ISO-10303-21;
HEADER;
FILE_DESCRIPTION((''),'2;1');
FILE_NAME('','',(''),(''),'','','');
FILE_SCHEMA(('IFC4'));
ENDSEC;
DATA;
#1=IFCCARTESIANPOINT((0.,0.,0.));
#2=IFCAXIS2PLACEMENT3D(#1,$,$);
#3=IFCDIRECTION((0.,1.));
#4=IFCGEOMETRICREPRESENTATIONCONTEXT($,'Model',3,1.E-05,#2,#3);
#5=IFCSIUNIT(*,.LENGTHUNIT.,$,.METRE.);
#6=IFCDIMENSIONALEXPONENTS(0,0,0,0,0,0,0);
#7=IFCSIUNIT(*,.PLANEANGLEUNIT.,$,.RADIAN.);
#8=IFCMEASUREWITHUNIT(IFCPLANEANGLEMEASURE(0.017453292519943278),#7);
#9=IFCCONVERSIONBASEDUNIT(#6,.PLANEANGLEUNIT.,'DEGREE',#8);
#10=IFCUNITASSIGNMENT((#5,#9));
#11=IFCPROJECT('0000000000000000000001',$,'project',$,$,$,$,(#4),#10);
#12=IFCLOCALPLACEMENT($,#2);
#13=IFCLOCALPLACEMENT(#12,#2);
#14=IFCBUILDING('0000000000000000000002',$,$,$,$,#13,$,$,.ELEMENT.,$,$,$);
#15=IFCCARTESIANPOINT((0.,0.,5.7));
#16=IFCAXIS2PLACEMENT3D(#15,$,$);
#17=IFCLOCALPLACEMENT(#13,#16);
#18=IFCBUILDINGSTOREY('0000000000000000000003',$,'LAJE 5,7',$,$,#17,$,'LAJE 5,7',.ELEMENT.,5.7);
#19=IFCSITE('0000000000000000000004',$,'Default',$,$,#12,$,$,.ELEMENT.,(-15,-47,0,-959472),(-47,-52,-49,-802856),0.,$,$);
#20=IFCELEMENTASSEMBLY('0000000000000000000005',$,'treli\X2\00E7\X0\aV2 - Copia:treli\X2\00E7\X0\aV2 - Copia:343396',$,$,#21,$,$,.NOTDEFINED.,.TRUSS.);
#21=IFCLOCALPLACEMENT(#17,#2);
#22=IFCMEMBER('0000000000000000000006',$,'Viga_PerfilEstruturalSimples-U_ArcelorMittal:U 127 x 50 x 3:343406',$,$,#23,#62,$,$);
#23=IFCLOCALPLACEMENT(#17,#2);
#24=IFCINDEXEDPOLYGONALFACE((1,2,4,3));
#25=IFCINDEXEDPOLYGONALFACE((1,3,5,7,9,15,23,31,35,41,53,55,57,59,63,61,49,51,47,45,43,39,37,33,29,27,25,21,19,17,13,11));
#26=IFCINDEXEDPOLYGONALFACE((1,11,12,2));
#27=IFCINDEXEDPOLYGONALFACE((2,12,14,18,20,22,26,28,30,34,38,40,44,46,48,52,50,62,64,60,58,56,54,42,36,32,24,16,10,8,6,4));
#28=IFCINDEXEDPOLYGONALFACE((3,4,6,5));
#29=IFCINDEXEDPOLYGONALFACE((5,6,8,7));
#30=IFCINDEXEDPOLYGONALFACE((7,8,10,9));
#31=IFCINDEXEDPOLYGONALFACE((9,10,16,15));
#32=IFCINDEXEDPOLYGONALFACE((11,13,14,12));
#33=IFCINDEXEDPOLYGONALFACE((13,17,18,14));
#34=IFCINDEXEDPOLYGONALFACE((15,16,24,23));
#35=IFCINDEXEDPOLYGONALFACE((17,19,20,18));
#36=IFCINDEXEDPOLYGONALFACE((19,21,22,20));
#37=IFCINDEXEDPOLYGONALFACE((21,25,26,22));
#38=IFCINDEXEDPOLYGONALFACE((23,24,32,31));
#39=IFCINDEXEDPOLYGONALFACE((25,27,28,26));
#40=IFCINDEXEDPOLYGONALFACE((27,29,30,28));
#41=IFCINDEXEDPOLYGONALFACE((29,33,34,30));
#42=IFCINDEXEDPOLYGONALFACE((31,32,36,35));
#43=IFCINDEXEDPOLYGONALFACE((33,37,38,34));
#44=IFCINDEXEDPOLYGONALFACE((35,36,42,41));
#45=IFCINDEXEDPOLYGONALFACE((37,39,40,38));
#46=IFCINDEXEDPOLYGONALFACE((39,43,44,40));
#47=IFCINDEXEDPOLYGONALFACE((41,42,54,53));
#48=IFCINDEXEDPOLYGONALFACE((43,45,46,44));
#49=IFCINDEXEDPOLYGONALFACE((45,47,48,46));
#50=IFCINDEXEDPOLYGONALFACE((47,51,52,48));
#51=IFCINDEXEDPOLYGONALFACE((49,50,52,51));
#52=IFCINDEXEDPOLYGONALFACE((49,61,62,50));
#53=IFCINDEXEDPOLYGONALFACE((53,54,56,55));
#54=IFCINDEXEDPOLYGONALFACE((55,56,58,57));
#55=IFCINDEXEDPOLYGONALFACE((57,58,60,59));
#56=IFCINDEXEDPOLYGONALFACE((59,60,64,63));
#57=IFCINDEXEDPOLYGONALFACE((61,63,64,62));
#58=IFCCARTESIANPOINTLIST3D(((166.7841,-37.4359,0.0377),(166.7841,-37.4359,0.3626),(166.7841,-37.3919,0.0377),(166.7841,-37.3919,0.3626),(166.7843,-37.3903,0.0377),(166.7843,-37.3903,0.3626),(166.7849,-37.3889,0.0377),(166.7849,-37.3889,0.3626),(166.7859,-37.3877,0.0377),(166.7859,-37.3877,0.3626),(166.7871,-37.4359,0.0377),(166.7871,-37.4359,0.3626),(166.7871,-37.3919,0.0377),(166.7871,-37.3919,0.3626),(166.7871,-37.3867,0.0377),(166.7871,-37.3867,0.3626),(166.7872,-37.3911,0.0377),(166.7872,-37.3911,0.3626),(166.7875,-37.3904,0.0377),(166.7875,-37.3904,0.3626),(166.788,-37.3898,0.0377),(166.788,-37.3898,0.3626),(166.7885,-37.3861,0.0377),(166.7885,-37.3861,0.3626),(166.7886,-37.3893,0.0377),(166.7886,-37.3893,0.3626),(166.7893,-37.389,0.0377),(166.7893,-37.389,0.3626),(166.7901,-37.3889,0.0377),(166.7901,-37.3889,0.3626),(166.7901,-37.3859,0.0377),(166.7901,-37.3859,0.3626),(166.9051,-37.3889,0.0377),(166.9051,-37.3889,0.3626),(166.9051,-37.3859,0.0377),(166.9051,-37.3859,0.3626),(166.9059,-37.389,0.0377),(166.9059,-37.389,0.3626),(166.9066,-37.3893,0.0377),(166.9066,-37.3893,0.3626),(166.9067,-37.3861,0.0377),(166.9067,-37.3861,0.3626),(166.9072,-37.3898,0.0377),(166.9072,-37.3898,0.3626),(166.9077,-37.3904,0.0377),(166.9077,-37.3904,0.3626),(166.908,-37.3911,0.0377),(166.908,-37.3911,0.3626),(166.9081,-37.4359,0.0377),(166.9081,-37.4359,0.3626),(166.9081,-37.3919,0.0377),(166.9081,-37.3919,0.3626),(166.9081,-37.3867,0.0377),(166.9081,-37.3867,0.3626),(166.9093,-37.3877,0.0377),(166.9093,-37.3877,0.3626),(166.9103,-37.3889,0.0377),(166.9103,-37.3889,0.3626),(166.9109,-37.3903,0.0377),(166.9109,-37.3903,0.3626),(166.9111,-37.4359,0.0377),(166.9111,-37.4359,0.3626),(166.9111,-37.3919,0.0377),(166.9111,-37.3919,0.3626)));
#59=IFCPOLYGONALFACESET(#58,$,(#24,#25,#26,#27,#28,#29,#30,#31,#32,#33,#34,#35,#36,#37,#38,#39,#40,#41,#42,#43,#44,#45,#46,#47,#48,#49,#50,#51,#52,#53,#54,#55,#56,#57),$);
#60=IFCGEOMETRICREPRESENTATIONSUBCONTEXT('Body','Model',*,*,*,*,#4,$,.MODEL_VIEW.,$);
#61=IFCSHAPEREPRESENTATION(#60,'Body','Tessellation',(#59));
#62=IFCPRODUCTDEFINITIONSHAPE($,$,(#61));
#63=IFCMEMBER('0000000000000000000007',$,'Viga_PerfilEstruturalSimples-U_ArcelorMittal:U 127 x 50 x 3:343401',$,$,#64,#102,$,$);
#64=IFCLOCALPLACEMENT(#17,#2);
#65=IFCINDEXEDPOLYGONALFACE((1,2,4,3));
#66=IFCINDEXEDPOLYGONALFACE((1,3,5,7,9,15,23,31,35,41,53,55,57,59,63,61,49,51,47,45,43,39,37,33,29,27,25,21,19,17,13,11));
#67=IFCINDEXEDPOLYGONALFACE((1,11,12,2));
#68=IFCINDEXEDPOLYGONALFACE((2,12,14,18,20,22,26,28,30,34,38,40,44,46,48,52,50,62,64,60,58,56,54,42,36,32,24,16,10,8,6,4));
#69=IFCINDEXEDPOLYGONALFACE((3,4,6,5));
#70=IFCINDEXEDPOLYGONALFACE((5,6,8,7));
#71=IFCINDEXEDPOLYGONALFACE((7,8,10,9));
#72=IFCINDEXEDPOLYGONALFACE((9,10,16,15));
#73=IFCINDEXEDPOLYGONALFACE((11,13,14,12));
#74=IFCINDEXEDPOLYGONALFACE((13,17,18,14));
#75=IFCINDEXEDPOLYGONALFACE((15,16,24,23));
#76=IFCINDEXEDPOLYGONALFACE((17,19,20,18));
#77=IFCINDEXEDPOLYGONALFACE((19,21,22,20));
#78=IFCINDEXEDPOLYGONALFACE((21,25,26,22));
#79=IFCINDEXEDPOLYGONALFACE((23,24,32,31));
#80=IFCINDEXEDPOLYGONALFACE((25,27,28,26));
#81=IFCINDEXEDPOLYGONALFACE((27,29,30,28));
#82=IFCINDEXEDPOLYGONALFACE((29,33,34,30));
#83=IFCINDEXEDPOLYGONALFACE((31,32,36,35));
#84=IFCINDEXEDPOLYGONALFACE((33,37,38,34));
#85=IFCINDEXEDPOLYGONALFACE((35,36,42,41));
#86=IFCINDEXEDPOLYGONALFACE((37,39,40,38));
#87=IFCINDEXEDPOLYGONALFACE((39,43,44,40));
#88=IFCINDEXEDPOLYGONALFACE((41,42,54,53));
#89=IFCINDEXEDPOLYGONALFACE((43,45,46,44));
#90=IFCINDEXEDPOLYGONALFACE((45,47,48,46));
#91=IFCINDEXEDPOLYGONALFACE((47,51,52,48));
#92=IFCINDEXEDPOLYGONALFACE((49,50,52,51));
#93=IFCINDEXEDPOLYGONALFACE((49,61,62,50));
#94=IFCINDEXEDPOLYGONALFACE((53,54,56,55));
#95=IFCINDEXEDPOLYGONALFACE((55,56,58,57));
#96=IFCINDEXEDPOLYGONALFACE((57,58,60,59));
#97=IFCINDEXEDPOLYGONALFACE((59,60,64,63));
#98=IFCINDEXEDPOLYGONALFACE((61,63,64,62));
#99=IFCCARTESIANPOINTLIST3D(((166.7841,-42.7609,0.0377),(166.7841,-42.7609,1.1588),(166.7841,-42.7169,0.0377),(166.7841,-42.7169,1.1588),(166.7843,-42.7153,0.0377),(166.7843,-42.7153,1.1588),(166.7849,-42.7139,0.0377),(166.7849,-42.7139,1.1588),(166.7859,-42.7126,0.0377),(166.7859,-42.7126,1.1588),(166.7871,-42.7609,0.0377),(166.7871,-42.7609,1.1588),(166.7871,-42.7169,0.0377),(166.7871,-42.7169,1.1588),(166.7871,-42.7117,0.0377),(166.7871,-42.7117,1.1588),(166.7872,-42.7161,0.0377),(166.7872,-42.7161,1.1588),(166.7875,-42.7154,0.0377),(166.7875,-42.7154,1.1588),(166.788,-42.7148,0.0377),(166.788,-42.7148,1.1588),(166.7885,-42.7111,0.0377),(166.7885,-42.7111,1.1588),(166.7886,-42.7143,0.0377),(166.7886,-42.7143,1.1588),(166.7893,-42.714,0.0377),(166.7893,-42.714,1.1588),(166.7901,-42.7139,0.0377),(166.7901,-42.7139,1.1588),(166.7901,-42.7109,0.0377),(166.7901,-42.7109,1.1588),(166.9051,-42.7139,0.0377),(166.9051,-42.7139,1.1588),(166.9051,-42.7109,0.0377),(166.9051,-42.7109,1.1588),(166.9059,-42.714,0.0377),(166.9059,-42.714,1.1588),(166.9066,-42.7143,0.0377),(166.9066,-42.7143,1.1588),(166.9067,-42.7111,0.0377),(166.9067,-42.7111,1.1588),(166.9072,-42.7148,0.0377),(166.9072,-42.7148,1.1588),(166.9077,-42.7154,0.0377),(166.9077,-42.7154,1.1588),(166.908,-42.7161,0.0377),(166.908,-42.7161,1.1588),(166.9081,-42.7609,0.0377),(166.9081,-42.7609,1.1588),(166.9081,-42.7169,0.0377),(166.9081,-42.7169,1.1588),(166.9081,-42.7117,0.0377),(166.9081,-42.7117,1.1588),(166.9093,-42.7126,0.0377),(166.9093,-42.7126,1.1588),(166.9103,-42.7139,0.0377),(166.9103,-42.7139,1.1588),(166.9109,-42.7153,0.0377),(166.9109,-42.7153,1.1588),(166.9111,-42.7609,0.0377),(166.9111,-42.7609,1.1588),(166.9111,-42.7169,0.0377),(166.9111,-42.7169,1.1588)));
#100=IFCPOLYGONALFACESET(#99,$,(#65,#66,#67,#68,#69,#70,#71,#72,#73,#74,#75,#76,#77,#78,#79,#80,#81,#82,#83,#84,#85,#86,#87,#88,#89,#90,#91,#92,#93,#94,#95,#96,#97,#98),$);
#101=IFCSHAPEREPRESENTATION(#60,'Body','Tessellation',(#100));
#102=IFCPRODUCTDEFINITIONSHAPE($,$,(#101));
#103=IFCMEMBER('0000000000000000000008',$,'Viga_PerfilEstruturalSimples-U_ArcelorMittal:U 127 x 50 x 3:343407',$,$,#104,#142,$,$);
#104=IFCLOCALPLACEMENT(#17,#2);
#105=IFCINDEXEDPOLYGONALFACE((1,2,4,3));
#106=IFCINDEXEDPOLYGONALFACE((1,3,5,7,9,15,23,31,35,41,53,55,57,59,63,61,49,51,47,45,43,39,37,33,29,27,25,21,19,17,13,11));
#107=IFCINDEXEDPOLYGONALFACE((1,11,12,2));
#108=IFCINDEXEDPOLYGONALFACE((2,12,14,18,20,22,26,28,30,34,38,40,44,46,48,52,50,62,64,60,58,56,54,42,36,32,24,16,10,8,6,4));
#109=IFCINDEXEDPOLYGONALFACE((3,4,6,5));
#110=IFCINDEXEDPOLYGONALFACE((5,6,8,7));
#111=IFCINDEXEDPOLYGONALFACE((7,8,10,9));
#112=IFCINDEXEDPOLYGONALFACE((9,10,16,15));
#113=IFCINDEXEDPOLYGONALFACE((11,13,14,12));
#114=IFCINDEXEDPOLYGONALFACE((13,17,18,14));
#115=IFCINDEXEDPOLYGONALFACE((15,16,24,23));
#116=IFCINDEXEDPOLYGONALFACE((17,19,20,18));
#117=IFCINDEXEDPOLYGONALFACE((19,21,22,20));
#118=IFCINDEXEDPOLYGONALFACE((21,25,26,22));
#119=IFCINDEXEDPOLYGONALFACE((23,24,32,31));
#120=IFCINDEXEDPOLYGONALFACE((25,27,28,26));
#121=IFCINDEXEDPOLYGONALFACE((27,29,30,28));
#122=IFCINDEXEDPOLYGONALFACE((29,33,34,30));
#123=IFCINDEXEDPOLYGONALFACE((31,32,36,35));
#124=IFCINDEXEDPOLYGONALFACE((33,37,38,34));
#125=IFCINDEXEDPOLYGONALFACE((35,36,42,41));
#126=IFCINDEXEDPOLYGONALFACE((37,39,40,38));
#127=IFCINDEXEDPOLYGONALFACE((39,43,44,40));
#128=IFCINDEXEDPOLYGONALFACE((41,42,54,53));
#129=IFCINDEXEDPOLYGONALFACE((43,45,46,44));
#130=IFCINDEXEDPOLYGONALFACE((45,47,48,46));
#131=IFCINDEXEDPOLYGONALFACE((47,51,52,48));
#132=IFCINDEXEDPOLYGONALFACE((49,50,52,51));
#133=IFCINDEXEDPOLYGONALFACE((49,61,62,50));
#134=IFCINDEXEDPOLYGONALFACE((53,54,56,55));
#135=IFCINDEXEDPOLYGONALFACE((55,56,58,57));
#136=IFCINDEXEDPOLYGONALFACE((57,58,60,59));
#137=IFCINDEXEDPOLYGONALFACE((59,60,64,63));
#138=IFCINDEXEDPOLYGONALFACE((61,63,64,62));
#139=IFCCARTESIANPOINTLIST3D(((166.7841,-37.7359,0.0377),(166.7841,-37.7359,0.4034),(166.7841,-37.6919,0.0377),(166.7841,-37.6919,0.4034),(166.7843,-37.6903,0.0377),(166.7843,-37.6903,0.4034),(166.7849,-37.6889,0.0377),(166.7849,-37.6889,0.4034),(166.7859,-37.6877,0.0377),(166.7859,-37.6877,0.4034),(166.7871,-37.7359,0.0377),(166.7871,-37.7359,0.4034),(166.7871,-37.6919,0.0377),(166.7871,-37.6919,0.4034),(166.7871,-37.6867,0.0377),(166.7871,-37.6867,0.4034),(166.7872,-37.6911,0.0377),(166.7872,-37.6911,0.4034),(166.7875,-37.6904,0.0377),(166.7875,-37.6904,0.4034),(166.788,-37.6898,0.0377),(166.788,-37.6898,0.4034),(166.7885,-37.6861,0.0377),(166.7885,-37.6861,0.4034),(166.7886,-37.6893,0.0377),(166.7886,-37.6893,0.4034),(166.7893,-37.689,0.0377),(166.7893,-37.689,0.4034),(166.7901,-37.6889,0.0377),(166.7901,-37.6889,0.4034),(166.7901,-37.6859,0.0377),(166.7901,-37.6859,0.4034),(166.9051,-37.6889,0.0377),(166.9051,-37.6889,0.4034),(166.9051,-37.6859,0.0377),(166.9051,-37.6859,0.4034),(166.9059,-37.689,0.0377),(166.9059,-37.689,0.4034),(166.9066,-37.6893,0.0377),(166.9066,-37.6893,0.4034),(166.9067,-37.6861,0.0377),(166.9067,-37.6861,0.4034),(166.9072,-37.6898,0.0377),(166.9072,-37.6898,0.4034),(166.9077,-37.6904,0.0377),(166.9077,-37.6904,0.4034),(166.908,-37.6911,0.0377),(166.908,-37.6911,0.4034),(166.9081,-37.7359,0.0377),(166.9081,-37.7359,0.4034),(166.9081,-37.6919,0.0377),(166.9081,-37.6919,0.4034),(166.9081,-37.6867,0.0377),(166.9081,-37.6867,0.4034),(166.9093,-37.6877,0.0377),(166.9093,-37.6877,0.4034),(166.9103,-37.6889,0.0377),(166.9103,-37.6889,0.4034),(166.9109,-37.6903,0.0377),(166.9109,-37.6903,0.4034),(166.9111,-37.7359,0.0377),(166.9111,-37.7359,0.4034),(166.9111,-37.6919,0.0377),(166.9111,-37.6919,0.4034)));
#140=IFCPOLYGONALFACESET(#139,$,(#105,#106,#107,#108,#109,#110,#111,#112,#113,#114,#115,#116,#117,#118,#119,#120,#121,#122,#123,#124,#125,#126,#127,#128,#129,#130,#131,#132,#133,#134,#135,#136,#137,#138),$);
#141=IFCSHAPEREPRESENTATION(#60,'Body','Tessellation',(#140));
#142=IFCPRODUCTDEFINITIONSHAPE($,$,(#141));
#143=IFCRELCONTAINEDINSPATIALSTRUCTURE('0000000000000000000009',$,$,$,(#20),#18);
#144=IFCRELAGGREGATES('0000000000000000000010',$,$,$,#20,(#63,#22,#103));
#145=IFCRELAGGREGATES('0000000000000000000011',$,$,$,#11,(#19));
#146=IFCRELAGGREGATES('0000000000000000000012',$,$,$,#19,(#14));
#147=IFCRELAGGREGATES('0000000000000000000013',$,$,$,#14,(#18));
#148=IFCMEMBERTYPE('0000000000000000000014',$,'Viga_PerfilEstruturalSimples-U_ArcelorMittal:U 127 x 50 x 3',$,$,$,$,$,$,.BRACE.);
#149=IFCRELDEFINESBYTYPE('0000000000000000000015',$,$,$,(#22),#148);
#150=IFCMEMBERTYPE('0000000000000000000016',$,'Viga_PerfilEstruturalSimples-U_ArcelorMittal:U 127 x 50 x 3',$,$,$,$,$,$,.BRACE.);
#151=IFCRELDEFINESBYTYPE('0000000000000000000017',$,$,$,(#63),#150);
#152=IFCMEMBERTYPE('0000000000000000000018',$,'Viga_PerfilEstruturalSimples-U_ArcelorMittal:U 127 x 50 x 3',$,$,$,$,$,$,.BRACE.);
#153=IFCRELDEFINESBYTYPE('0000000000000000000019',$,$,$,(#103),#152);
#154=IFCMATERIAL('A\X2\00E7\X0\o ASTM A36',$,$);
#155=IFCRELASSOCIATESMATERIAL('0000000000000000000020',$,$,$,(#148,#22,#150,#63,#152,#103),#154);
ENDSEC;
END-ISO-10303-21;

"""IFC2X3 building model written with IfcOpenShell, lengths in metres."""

from ifc_helpers import new_model, entity, si_unit, converted_unit, direction, frame, frame_2d, origin, place, context, subcontext, project, spatial, polyline, circle_curve, parameter, trimmed, segment, composite_curve, outline, extrude, source, transform, mapped, material, type_object, type_shapes, element, aggregate, save


model = new_model("IFC2X3")

# Units and contexts
model_context = context("Model", 3, precision=1e-05, world=origin(), true_north=direction((0.0, 1.0)))
body_context = subcontext(model_context, "Body", "Model", "MODEL_VIEW")
ifc_project = project(units=[si_unit("LENGTHUNIT", "METRE"), converted_unit("PLANEANGLEUNIT", "DEGREE", entity("IfcPlaneAngleMeasure", 0.017453292519943278), si_unit("PLANEANGLEUNIT", "RADIAN"), dimensions=[0, 0, 0, 0, 0, 0, 0])], contexts=[model_context])

# Site, building, storey
site_placement = place(None, origin())
site = spatial("IfcSite", under=ifc_project, at=site_placement, Name="Default", CompositionType="ELEMENT", RefLatitude=(-15, -47, 0, -959472), RefLongitude=(-47, -52, -49, -802856), RefElevation=0.0)
building_placement = place(site_placement, origin())
building = spatial("IfcBuilding", under=site, at=building_placement, CompositionType="ELEMENT")
storey_placement = place(building_placement, frame((0.0, 0.0, 5.7)))
storey = spatial("IfcBuildingStorey", under=building, at=storey_placement, Name="LAJE 5,7", LongName="LAJE 5,7", CompositionType="ELEMENT", Elevation=5.7)

# Element assembly, member
assembly_1_placement = place(storey_placement, origin())
assembly_1 = element("IfcElementAssembly", 1, at=assembly_1_placement, inside=storey, Name="treliçaV2 - Copia:treliçaV2 - Copia:343396", AssemblyPlace="NOTDEFINED", PredefinedType="TRUSS")
ifc_material = material(Name="Aço ASTM A36")
member_type_1 = type_object("IfcMemberType", Name="Viga_PerfilEstruturalSimples-U_ArcelorMittal:U 127 x 50 x 3", PredefinedType="BRACE", material=ifc_material)
shared_shape_1 = source(origin(), body_context, "Body", "SweptSolid", [
    extrude(outline(composite_curve([segment(polyline([(-0.0575, -0.0192), (0.0575, -0.0192)]), True, "CONTINUOUS"), segment(trimmed(circle_curve(frame_2d((0.0575, -0.0132), x_axis=(0.0, 1.0)), 0.006), [parameter(180.0)], [parameter(270.0)], True, "PARAMETER"), True, "CONTINUOUS"), segment(polyline([(0.0635, -0.0132), (0.0635, 0.0308)]), True, "CONTINUOUS"), segment(polyline([(0.0635, 0.0308), (0.0605, 0.0308)]), True, "CONTINUOUS"), segment(polyline([(0.0605, 0.0308), (0.0605, -0.0132)]), True, "CONTINUOUS"), segment(trimmed(circle_curve(frame_2d((0.0575, -0.0132), x_axis=(0.0, 1.0)), 0.003), [parameter(180.0)], [parameter(270.0)], True, "PARAMETER"), False, "CONTINUOUS"), segment(polyline([(0.0575, -0.0162), (-0.0575, -0.0162)]), True, "CONTINUOUS"), segment(trimmed(circle_curve(frame_2d((-0.0575, -0.0132), x_axis=(0.0, 1.0)), 0.003), [parameter(90.0)], [parameter(180.0)], True, "PARAMETER"), False, "CONTINUOUS"), segment(polyline([(-0.0605, -0.0132), (-0.0605, 0.0308)]), True, "CONTINUOUS"), segment(polyline([(-0.0605, 0.0308), (-0.0635, 0.0308)]), True, "CONTINUOUS"), segment(polyline([(-0.0635, 0.0308), (-0.0635, -0.0132)]), True, "CONTINUOUS"), segment(trimmed(circle_curve(frame_2d((-0.0575, -0.0132), x_axis=(0.0, 1.0)), 0.006), [parameter(90.0)], [parameter(180.0)], True, "PARAMETER"), True, "CONTINUOUS")], self_intersect=False)), frame((-0.1623, -0.0058, 0.0), z_axis=(1.0, 0.0, 0.0), x_axis=(0.0, 0.0, -1.0)), (0.0, 0.0, 1.0), 0.3249),
])
type_shapes(member_type_1, [shared_shape_1])
member_1_placement = place(assembly_1_placement, frame((166.8476, -37.4109, 0.2), z_axis=(1.0, 0.0, 0.0), x_axis=(0.0, 0.0, 1.0)))
member_1 = element("IfcMember", 2, at=member_1_placement, type_object=member_type_1, material=ifc_material, Name="Viga_PerfilEstruturalSimples-U_ArcelorMittal:U 127 x 50 x 3:343406", context=body_context, shape_type="MappedRepresentation", body=[
    mapped(shared_shape_1, transform((0.0, 0.0, 0.0), scale=1.0)),
])

# Members
member_type_2 = type_object("IfcMemberType", Name="Viga_PerfilEstruturalSimples-U_ArcelorMittal:U 127 x 50 x 3", PredefinedType="BRACE", material=ifc_material)
shared_shape_2 = source(origin(), body_context, "Body", "SweptSolid", [
    extrude(outline(composite_curve([segment(polyline([(-0.0575, -0.0192), (0.0575, -0.0192)]), True, "CONTINUOUS"), segment(trimmed(circle_curve(frame_2d((0.0575, -0.0132), x_axis=(0.0, 1.0)), 0.006), [parameter(180.0)], [parameter(270.0)], True, "PARAMETER"), True, "CONTINUOUS"), segment(polyline([(0.0635, -0.0132), (0.0635, 0.0308)]), True, "CONTINUOUS"), segment(polyline([(0.0635, 0.0308), (0.0605, 0.0308)]), True, "CONTINUOUS"), segment(polyline([(0.0605, 0.0308), (0.0605, -0.0132)]), True, "CONTINUOUS"), segment(trimmed(circle_curve(frame_2d((0.0575, -0.0132), x_axis=(0.0, 1.0)), 0.003), [parameter(180.0)], [parameter(270.0)], True, "PARAMETER"), False, "CONTINUOUS"), segment(polyline([(0.0575, -0.0162), (-0.0575, -0.0162)]), True, "CONTINUOUS"), segment(trimmed(circle_curve(frame_2d((-0.0575, -0.0132), x_axis=(0.0, 1.0)), 0.003), [parameter(90.0)], [parameter(180.0)], True, "PARAMETER"), False, "CONTINUOUS"), segment(polyline([(-0.0605, -0.0132), (-0.0605, 0.0308)]), True, "CONTINUOUS"), segment(polyline([(-0.0605, 0.0308), (-0.0635, 0.0308)]), True, "CONTINUOUS"), segment(polyline([(-0.0635, 0.0308), (-0.0635, -0.0132)]), True, "CONTINUOUS"), segment(trimmed(circle_curve(frame_2d((-0.0575, -0.0132), x_axis=(0.0, 1.0)), 0.006), [parameter(90.0)], [parameter(180.0)], True, "PARAMETER"), True, "CONTINUOUS")], self_intersect=False)), frame((-0.5626, -0.0058, 0.0), z_axis=(1.0, 0.0, 0.0), x_axis=(0.0, 0.0, -1.0)), (0.0, 0.0, 1.0), 1.1211),
])
type_shapes(member_type_2, [shared_shape_2])
member_2_placement = place(assembly_1_placement, frame((166.8476, -42.7359, 0.6003), z_axis=(1.0, 0.0, 0.0), x_axis=(0.0, 0.0, 1.0)))
member_2 = element("IfcMember", 3, at=member_2_placement, type_object=member_type_2, material=ifc_material, Name="Viga_PerfilEstruturalSimples-U_ArcelorMittal:U 127 x 50 x 3:343401", context=body_context, shape_type="MappedRepresentation", body=[
    mapped(shared_shape_2, transform((0.0, 0.0, 0.0), scale=1.0)),
])
member_type_3 = type_object("IfcMemberType", Name="Viga_PerfilEstruturalSimples-U_ArcelorMittal:U 127 x 50 x 3", PredefinedType="BRACE", material=ifc_material)
shared_shape_3 = source(origin(), body_context, "Body", "SweptSolid", [
    extrude(outline(composite_curve([segment(polyline([(-0.0575, -0.0192), (0.0575, -0.0192)]), True, "CONTINUOUS"), segment(trimmed(circle_curve(frame_2d((0.0575, -0.0132), x_axis=(0.0, 1.0)), 0.006), [parameter(180.0)], [parameter(270.0)], True, "PARAMETER"), True, "CONTINUOUS"), segment(polyline([(0.0635, -0.0132), (0.0635, 0.0308)]), True, "CONTINUOUS"), segment(polyline([(0.0635, 0.0308), (0.0605, 0.0308)]), True, "CONTINUOUS"), segment(polyline([(0.0605, 0.0308), (0.0605, -0.0132)]), True, "CONTINUOUS"), segment(trimmed(circle_curve(frame_2d((0.0575, -0.0132), x_axis=(0.0, 1.0)), 0.003), [parameter(180.0)], [parameter(270.0)], True, "PARAMETER"), False, "CONTINUOUS"), segment(polyline([(0.0575, -0.0162), (-0.0575, -0.0162)]), True, "CONTINUOUS"), segment(trimmed(circle_curve(frame_2d((-0.0575, -0.0132), x_axis=(0.0, 1.0)), 0.003), [parameter(90.0)], [parameter(180.0)], True, "PARAMETER"), False, "CONTINUOUS"), segment(polyline([(-0.0605, -0.0132), (-0.0605, 0.0308)]), True, "CONTINUOUS"), segment(polyline([(-0.0605, 0.0308), (-0.0635, 0.0308)]), True, "CONTINUOUS"), segment(polyline([(-0.0635, 0.0308), (-0.0635, -0.0132)]), True, "CONTINUOUS"), segment(trimmed(circle_curve(frame_2d((-0.0575, -0.0132), x_axis=(0.0, 1.0)), 0.006), [parameter(90.0)], [parameter(180.0)], True, "PARAMETER"), True, "CONTINUOUS")], self_intersect=False)), frame((-0.1849, -0.0058, 0.0), z_axis=(1.0, 0.0, 0.0), x_axis=(0.0, 0.0, -1.0)), (0.0, 0.0, 1.0), 0.3657),
])
type_shapes(member_type_3, [shared_shape_3])
member_3_placement = place(assembly_1_placement, frame((166.8476, -37.7109, 0.2226), z_axis=(1.0, 0.0, 0.0), x_axis=(0.0, 0.0, 1.0)))
member_3 = element("IfcMember", 4, at=member_3_placement, type_object=member_type_3, material=ifc_material, Name="Viga_PerfilEstruturalSimples-U_ArcelorMittal:U 127 x 50 x 3:343407", context=body_context, shape_type="MappedRepresentation", body=[
    mapped(shared_shape_3, transform((0.0, 0.0, 0.0), scale=1.0)),
])

aggregate(assembly_1, [member_2, member_1, member_3])

save(model, "model.ifc")
